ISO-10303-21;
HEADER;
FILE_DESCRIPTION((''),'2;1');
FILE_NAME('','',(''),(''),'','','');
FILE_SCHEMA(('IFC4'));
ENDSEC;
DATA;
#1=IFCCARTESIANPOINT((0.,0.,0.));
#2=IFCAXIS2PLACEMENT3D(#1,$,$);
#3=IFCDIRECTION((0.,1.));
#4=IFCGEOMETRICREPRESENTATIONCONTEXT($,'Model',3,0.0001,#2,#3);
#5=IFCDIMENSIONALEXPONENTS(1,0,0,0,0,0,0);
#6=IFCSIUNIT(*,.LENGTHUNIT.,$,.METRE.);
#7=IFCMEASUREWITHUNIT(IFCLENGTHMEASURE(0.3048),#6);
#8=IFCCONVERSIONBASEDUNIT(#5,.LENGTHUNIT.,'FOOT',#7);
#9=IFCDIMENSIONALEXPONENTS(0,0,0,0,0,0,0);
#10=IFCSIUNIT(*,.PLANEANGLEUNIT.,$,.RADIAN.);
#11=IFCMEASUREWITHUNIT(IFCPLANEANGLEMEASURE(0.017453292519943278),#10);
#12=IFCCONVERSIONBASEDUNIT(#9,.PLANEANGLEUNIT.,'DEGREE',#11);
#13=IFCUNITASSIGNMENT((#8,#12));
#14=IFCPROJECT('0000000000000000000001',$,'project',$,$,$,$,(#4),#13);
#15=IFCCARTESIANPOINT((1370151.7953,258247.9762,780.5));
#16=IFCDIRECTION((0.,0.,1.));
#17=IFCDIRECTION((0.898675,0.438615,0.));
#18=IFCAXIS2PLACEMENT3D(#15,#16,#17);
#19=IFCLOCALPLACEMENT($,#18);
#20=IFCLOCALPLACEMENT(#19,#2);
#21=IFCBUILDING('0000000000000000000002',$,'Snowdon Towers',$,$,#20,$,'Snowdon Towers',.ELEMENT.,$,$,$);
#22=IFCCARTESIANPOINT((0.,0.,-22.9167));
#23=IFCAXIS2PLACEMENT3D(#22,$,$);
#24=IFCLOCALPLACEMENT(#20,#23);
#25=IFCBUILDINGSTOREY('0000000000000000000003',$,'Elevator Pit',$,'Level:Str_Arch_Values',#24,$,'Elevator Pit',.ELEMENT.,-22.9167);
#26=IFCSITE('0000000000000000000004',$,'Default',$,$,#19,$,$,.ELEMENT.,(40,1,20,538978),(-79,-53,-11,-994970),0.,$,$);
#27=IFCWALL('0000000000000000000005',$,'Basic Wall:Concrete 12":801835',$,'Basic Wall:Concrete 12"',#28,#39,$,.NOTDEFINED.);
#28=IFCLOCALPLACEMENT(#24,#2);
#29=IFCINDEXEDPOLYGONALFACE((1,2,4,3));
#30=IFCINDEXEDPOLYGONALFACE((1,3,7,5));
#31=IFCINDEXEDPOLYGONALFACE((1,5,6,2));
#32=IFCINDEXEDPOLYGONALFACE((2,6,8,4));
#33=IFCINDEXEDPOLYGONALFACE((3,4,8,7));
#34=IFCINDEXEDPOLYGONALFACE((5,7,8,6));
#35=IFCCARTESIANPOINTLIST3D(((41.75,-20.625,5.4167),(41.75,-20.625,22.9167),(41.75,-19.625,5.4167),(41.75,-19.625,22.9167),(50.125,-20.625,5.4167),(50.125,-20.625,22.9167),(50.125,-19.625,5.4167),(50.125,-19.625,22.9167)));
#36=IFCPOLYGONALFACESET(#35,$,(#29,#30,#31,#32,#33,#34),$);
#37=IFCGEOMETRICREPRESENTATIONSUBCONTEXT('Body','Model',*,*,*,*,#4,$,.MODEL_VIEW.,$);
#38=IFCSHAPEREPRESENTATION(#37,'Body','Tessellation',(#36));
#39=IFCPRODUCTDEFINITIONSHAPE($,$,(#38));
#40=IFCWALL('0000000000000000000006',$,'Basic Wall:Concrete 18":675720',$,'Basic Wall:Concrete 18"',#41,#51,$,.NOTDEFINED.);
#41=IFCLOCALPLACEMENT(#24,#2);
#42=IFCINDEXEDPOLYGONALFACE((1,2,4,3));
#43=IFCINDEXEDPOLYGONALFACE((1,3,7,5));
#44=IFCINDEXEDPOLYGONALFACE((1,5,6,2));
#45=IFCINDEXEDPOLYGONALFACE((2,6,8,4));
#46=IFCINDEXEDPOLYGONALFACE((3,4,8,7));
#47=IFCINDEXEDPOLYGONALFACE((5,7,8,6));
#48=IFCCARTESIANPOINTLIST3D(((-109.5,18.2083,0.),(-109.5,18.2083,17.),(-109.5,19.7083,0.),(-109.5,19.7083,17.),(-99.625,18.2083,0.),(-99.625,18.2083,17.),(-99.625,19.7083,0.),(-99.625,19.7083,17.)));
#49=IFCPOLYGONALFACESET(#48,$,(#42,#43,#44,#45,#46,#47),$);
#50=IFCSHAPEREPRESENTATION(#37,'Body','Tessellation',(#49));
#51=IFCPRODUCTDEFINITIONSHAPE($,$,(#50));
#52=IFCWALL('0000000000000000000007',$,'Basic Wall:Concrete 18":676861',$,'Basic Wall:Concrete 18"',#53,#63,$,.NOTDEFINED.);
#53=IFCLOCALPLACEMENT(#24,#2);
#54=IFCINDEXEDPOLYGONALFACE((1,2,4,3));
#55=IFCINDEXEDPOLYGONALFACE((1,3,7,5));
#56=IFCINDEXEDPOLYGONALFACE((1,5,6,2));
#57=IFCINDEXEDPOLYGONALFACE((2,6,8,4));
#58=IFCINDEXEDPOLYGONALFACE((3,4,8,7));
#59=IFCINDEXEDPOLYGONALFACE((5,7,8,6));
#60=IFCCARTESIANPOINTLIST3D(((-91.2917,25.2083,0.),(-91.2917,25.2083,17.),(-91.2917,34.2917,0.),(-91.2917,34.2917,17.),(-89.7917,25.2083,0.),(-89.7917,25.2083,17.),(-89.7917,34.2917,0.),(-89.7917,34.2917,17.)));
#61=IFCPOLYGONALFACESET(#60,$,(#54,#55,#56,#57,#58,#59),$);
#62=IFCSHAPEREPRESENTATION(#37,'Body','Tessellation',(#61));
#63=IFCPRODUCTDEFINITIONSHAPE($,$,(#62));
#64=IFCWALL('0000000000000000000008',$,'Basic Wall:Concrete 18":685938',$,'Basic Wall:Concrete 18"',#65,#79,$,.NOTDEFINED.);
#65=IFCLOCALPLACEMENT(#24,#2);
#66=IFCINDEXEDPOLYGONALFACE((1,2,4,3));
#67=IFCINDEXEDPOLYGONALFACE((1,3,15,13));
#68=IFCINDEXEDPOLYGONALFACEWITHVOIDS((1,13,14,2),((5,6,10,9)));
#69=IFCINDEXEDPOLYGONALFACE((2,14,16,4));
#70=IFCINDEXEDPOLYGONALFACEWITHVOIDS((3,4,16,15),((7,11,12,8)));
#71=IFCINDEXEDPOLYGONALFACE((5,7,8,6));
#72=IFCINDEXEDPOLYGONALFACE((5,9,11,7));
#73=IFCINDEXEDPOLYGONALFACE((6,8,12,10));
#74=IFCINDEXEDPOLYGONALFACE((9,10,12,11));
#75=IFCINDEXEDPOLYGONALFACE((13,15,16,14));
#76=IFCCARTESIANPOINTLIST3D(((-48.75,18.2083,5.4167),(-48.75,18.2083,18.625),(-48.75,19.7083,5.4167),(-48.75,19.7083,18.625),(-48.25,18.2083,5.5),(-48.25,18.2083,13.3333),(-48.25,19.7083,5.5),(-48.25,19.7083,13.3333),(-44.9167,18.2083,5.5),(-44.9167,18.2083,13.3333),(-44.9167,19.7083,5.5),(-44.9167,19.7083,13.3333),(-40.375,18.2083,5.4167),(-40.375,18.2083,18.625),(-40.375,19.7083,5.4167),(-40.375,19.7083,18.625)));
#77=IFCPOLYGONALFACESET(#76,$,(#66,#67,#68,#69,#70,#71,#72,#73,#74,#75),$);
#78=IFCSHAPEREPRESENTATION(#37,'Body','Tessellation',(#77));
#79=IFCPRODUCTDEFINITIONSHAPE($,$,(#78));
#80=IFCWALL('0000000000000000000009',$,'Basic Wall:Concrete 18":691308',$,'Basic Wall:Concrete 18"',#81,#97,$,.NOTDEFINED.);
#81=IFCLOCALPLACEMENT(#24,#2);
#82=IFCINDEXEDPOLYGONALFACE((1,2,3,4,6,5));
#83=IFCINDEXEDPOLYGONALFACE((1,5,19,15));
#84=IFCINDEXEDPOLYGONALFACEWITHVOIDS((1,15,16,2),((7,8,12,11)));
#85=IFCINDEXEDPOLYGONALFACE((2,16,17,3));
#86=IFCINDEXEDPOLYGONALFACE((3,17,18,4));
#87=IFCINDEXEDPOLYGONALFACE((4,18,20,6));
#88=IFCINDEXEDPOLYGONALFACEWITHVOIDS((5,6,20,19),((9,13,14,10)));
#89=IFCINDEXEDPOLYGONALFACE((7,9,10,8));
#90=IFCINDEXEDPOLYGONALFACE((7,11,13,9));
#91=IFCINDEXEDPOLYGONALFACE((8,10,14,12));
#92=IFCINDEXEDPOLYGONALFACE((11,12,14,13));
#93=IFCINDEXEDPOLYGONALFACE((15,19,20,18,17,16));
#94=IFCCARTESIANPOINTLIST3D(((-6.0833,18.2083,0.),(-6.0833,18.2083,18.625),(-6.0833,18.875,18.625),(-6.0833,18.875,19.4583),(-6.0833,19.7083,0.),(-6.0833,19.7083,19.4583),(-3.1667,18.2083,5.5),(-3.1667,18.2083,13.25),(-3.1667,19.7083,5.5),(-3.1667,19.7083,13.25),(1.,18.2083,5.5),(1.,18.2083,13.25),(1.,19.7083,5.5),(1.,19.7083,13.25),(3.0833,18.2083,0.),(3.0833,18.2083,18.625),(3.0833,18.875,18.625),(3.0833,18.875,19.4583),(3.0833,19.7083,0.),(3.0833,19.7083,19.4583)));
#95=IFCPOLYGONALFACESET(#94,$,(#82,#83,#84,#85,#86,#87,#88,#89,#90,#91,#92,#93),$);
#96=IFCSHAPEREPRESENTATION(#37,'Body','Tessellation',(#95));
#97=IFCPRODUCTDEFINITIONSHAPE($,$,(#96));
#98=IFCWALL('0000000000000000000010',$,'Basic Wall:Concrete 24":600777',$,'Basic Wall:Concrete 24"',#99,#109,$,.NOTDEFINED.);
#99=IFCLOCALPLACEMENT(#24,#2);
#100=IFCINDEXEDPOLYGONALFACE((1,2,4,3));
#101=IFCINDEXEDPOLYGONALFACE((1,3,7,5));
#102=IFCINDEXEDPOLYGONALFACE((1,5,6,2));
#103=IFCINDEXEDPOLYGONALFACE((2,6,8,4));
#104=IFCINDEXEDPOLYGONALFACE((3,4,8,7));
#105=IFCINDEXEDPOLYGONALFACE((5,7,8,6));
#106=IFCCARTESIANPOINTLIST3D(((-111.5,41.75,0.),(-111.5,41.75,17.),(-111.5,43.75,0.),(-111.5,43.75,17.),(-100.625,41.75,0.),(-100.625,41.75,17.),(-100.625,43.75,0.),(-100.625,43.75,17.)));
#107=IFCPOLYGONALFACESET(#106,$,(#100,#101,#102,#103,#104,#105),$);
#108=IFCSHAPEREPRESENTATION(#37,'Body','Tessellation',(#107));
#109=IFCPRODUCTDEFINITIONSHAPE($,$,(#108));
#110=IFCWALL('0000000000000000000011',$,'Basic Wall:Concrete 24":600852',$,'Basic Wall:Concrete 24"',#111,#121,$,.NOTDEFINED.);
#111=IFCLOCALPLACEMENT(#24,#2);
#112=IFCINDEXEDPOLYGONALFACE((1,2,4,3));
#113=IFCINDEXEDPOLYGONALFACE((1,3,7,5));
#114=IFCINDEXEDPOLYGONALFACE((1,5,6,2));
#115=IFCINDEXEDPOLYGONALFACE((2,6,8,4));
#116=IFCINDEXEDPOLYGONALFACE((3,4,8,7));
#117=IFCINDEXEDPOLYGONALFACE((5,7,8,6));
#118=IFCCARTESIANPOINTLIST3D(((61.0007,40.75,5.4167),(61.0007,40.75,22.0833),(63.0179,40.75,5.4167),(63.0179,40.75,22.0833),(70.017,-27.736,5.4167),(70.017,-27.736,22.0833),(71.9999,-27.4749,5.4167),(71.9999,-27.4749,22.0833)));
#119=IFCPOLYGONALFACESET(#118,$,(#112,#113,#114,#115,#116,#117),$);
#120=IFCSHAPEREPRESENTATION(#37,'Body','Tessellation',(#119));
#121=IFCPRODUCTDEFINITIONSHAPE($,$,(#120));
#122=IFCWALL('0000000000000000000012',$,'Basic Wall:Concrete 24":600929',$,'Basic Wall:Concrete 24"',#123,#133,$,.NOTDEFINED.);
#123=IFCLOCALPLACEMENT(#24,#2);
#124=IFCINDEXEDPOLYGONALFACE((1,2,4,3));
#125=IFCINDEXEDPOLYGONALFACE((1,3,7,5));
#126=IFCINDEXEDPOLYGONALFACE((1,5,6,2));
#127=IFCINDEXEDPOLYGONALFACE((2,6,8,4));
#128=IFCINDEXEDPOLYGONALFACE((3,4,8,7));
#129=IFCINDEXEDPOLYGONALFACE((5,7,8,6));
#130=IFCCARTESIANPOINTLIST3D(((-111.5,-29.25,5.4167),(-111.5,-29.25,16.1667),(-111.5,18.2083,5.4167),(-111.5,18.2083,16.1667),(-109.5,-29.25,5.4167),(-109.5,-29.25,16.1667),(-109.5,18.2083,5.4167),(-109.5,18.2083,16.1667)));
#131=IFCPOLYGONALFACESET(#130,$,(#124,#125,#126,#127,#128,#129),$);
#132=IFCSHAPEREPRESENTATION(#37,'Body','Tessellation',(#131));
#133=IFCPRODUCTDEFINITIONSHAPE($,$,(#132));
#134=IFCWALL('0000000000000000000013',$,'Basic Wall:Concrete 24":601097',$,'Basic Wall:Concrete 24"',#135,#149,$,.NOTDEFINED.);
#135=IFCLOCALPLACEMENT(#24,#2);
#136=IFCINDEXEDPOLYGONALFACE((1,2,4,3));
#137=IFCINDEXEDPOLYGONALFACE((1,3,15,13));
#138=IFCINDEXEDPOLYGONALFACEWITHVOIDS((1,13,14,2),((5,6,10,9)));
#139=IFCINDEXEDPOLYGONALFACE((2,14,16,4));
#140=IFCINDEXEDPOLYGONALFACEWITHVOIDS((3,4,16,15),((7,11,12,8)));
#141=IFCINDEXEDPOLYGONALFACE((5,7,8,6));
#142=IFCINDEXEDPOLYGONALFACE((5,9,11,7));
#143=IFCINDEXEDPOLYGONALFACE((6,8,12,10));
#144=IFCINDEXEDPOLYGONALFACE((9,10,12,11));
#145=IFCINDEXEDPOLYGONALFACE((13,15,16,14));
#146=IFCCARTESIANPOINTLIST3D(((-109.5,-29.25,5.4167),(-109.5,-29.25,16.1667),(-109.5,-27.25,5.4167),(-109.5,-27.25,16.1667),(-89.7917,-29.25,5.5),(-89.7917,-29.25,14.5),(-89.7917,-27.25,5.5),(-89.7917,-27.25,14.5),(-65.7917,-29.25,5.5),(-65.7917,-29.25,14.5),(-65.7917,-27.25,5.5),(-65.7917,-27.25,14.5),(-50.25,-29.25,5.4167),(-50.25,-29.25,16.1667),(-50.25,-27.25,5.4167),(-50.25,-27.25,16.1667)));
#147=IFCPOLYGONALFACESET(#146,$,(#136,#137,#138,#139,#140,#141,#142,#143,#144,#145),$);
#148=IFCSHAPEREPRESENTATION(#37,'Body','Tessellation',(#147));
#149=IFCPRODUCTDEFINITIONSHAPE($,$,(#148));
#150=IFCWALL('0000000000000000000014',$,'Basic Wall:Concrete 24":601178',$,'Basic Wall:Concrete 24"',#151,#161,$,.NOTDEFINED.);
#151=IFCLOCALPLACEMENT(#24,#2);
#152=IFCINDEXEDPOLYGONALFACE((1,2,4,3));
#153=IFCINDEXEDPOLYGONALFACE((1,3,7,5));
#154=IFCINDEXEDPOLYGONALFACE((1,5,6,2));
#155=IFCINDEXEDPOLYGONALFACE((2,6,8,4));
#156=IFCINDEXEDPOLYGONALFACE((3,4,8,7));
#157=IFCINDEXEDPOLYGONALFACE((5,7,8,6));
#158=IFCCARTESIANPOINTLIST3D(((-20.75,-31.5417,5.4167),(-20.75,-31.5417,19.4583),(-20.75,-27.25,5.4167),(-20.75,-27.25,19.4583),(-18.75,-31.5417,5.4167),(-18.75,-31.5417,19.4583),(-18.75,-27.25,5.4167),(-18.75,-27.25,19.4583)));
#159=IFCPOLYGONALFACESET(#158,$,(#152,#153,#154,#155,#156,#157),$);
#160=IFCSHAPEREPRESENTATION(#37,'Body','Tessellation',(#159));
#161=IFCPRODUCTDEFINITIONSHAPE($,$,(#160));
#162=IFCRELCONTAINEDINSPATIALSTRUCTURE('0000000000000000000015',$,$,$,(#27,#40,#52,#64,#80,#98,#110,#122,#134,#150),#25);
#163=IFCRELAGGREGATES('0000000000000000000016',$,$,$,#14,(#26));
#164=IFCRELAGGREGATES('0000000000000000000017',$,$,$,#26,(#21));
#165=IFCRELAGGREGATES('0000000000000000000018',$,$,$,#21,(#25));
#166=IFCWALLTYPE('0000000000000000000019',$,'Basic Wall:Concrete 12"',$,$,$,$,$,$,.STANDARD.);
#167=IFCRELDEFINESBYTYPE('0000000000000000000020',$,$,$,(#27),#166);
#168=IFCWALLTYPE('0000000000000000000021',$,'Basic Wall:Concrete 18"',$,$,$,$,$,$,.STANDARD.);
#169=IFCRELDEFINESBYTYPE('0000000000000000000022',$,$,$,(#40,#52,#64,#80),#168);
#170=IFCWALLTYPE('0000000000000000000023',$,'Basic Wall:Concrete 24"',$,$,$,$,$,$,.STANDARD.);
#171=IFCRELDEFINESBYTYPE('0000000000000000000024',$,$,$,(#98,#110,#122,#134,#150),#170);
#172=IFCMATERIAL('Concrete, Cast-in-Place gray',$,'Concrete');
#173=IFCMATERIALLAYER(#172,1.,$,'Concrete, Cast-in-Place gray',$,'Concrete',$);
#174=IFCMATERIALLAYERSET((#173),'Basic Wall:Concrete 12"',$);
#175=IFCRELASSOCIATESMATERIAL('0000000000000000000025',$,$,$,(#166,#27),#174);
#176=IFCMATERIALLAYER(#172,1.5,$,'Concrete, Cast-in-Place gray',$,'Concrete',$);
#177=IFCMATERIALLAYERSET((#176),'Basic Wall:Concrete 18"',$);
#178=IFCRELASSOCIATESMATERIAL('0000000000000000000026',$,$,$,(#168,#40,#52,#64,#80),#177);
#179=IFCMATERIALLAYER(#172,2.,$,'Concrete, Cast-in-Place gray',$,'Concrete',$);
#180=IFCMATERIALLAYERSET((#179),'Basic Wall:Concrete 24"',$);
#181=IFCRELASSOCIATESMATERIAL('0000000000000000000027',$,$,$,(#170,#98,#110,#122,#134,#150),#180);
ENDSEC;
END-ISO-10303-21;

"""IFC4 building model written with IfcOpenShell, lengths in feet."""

from ifc_helpers import new_model, entity, si_unit, converted_unit, direction, frame, frame_2d, origin, origin_2d_with_axis, place, context, subcontext, project, spatial, polyline, rectangle, outline, extrude, clip, bounded_halfspace, material, layer, layer_set, layer_usage, type_object, element, save


model = new_model("IFC4")

# Units and contexts
model_context = context("Model", 3, precision=0.0001, world=origin(), true_north=direction((0.0, 1.0)))
body_context = subcontext(model_context, "Body", "Model", "MODEL_VIEW")
ifc_project = project(units=[converted_unit("LENGTHUNIT", "FOOT", entity("IfcLengthMeasure", 0.3048), si_unit("LENGTHUNIT", "METRE"), dimensions=[1, 0, 0, 0, 0, 0, 0]), converted_unit("PLANEANGLEUNIT", "DEGREE", entity("IfcPlaneAngleMeasure", 0.017453292519943278), si_unit("PLANEANGLEUNIT", "RADIAN"), dimensions=[0, 0, 0, 0, 0, 0, 0])], contexts=[model_context])

# Site, building, storey
site_placement = place(None, frame((1370151.7953, 258247.9762, 780.5), z_axis=(0.0, 0.0, 1.0), x_axis=(0.898675, 0.438615, 0.0)))
site = spatial("IfcSite", under=ifc_project, at=site_placement, Name="Default", CompositionType="ELEMENT", RefLatitude=(40, 1, 20, 538978), RefLongitude=(-79, -53, -11, -994970), RefElevation=0.0)
building_placement = place(site_placement, origin())
building = spatial("IfcBuilding", under=site, at=building_placement, Name="Snowdon Towers", LongName="Snowdon Towers", CompositionType="ELEMENT")
storey_placement = place(building_placement, frame((0.0, 0.0, -22.9167)))
storey = spatial("IfcBuildingStorey", under=building, at=storey_placement, Name="Elevator Pit", ObjectType="Level:Str_Arch_Values", LongName="Elevator Pit", CompositionType="ELEMENT", Elevation=-22.9167)

# Shared definitions
ifc_material = material(Name="Concrete, Cast-in-Place gray", Category="Concrete")

# Shared definitions
ifc_layer_1 = layer(ifc_material, 1.0, Name="Concrete, Cast-in-Place gray", Category="Concrete")
ifc_layer_set_1 = layer_set([ifc_layer_1], Name="Basic Wall:Concrete 12\"")
wall_type_1 = type_object("IfcWallType", Name="Basic Wall:Concrete 12\"", PredefinedType="STANDARD", material=ifc_layer_set_1)

# Walls
ifc_layer_usage_1 = layer_usage(ifc_layer_set_1, "AXIS2", "POSITIVE", -0.5)
wall_1_placement = place(storey_placement, frame((50.125, -20.125, 5.4167), z_axis=(0.0, 0.0, 1.0), x_axis=(-1.0, 0.0, 0.0)))
element("IfcWall", 1, at=wall_1_placement, inside=storey, type_object=wall_type_1, material=ifc_layer_usage_1, Name="Basic Wall:Concrete 12\":801835", ObjectType="Basic Wall:Concrete 12\"", PredefinedType="NOTDEFINED", context=body_context, shape_type="SweptSolid", body=[
    extrude(rectangle(XDim=8.375, YDim=1.0, at=frame_2d((4.1875, 0.0), x_axis=(-1.0, 0.0))), origin(), (0.0, 0.0, 1.0), 17.5),
])
ifc_layer_2 = layer(ifc_material, 1.5, Name="Concrete, Cast-in-Place gray", Category="Concrete")
ifc_layer_set_2 = layer_set([ifc_layer_2], Name="Basic Wall:Concrete 18\"")
ifc_layer_usage_2 = layer_usage(ifc_layer_set_2, "AXIS2", "POSITIVE", -0.75)
wall_type_2 = type_object("IfcWallType", Name="Basic Wall:Concrete 18\"", PredefinedType="STANDARD", material=ifc_layer_set_2)
wall_2_placement = place(storey_placement, frame((-99.625, 18.9583, 0.0), z_axis=(0.0, 0.0, 1.0), x_axis=(-1.0, 0.0, 0.0)))
element("IfcWall", 2, at=wall_2_placement, inside=storey, type_object=wall_type_2, material=ifc_layer_usage_2, Name="Basic Wall:Concrete 18\":675720", ObjectType="Basic Wall:Concrete 18\"", PredefinedType="NOTDEFINED", context=body_context, shape_type="SweptSolid", body=[
    extrude(rectangle(XDim=9.875, YDim=1.5, at=frame_2d((4.9375, 0.0), x_axis=(-1.0, 0.0))), origin(), (0.0, 0.0, 1.0), 17.0),
])
ifc_layer_usage_3 = layer_usage(ifc_layer_set_2, "AXIS2", "POSITIVE", -0.75)
wall_3_placement = place(storey_placement, frame((-90.5417, 34.2917, 0.0), z_axis=(0.0, 0.0, 1.0), x_axis=(0.0, -1.0, 0.0)))
element("IfcWall", 3, at=wall_3_placement, inside=storey, type_object=wall_type_2, material=ifc_layer_usage_3, Name="Basic Wall:Concrete 18\":676861", ObjectType="Basic Wall:Concrete 18\"", PredefinedType="NOTDEFINED", context=body_context, shape_type="SweptSolid", body=[
    extrude(rectangle(XDim=9.0833, YDim=1.5, at=frame_2d((4.5417, 0.0), x_axis=(-1.0, 0.0))), origin(), (0.0, 0.0, 1.0), 17.0),
])

# Walls, openings
ifc_layer_usage_4 = layer_usage(ifc_layer_set_2, "AXIS2", "POSITIVE", -0.75)
wall_4_placement = place(storey_placement, frame((-40.375, 18.9583, 5.4167), z_axis=(0.0, 0.0, 1.0), x_axis=(-1.0, 0.0, 0.0)))
wall_4 = element("IfcWall", 4, at=wall_4_placement, inside=storey, type_object=wall_type_2, material=ifc_layer_usage_4, Name="Basic Wall:Concrete 18\":685938", ObjectType="Basic Wall:Concrete 18\"", PredefinedType="NOTDEFINED", context=body_context, shape_type="Clipping", body=[
    clip(extrude(rectangle(XDim=8.375, YDim=1.5, at=frame_2d((4.1875, 0.0), x_axis=(-1.0, 0.0))), origin(), (0.0, 0.0, 1.0), 13.2083), bounded_halfspace(frame((0.0, -0.75, 13.2083), z_axis=(0.0, 0.0, -1.0), x_axis=(1.0, 0.0, 0.0)), True, frame((0.0, -0.75, 13.2083), z_axis=(0.0, 0.0, -1.0), x_axis=(1.0, 0.0, 0.0)), polyline([(0.0, 0.0), (0.0, -1.5), (7.875, -1.5), (8.375, -1.5), (8.375, 0.0), (0.0, 0.0)]))),
])
opening_1_placement = place(wall_4_placement, origin())
element("IfcOpeningElement", 5, at=opening_1_placement, cuts=wall_4, PredefinedType="OPENING", context=body_context, shape_type="SweptSolid", body=[
    extrude(rectangle(XDim=7.8333, YDim=3.3333, at=frame_2d((0.0, 0.0), x_axis=(0.0, 1.0))), frame((6.2083, -5.75, 4.0), z_axis=(0.0, 1.0, 0.0), x_axis=(-1.0, 0.0, 0.0)), (0.0, 0.0, 1.0), 10.0),
])
ifc_layer_usage_5 = layer_usage(ifc_layer_set_2, "AXIS2", "NEGATIVE", 0.75)
wall_5_placement = place(storey_placement, frame((-6.0833, 18.9583, 0.0)))
wall_5 = element("IfcWall", 6, at=wall_5_placement, inside=storey, type_object=wall_type_2, material=ifc_layer_usage_5, Name="Basic Wall:Concrete 18\":691308", ObjectType="Basic Wall:Concrete 18\"", PredefinedType="NOTDEFINED", context=body_context, shape_type="Clipping", body=[
    clip(clip(extrude(rectangle(XDim=9.1667, YDim=1.5, at=frame_2d((4.5833, 0.0), x_axis=(-1.0, 0.0))), origin(), (0.0, 0.0, 1.0), 19.4583), bounded_halfspace(frame((9.1667, -0.0833, 18.625), z_axis=(0.0, 0.0, -1.0), x_axis=(-1.0, 0.0, 0.0)), True, frame((9.1667, -0.0833, 18.625), z_axis=(0.0, 0.0, -1.0), x_axis=(-1.0, 0.0, 0.0)), polyline([(0.0, 0.0), (0.0, -0.6667), (0.5, -0.6667), (9.1667, -0.6667), (9.1667, 0.0), (0.0, 0.0)]))), bounded_halfspace(frame((0.0, -0.0833, 18.625), z_axis=(0.0, 1.0, 0.0), x_axis=(0.0, 0.0, 1.0)), True, frame((0.0, -0.0833, 18.625), z_axis=(0.0, 1.0, 0.0), x_axis=(0.0, 0.0, 1.0)), polyline([(0.0, 0.0), (0.8333, 0.0), (0.8333, 9.1667), (0.0, 9.1667), (0.0, 0.0)]))),
])
opening_2_placement = place(wall_5_placement, origin())
element("IfcOpeningElement", 7, at=opening_2_placement, cuts=wall_5, PredefinedType="OPENING", context=body_context, shape_type="SweptSolid", body=[
    extrude(rectangle(XDim=7.75, YDim=4.1667, at=origin_2d_with_axis()), frame((5.0, -4.25, 9.375), z_axis=(0.0, 1.0, 0.0), x_axis=(0.0, 0.0, 1.0)), (0.0, 0.0, 1.0), 10.0),
])

# Walls
ifc_layer_3 = layer(ifc_material, 2.0, Name="Concrete, Cast-in-Place gray", Category="Concrete")
ifc_layer_set_3 = layer_set([ifc_layer_3], Name="Basic Wall:Concrete 24\"")
ifc_layer_usage_6 = layer_usage(ifc_layer_set_3, "AXIS2", "NEGATIVE", 1.0)
wall_type_3 = type_object("IfcWallType", Name="Basic Wall:Concrete 24\"", PredefinedType="STANDARD", material=ifc_layer_set_3)
wall_6_placement = place(storey_placement, frame((-111.5, 42.75, 0.0)))
element("IfcWall", 8, at=wall_6_placement, inside=storey, type_object=wall_type_3, material=ifc_layer_usage_6, Name="Basic Wall:Concrete 24\":600777", ObjectType="Basic Wall:Concrete 24\"", PredefinedType="NOTDEFINED", context=body_context, shape_type="SweptSolid", body=[
    extrude(rectangle(XDim=10.875, YDim=2.0, at=frame_2d((5.4375, 0.0), x_axis=(-1.0, 0.0))), origin(), (0.0, 0.0, 1.0), 17.0),
])
ifc_layer_usage_7 = layer_usage(ifc_layer_set_3, "AXIS2", "NEGATIVE", 1.0)
wall_7_placement = place(storey_placement, frame((61.9921, 40.8805, 5.4167), z_axis=(0.0, 0.0, 1.0), x_axis=(0.130526, -0.991445, 0.0)))
element("IfcWall", 9, at=wall_7_placement, inside=storey, type_object=wall_type_3, material=ifc_layer_usage_7, Name="Basic Wall:Concrete 24\":600852", ObjectType="Basic Wall:Concrete 24\"", PredefinedType="NOTDEFINED", context=body_context, shape_type="Clipping", body=[
    clip(extrude(outline(polyline([(69.0769, -1.0), (69.0769, 1.0), (0.2633, 1.0), (0.0, -1.0), (67.0769, -1.0), (69.0769, -1.0)])), origin(), (0.0, 0.0, 1.0), 16.6667), bounded_halfspace(frame((0.0, -1.0, 16.6667), z_axis=(0.0, 0.0, -1.0), x_axis=(-0.130526, -0.991445, 0.0)), True, frame((0.0, -1.0, 16.6667), z_axis=(0.0, 0.0, -1.0), x_axis=(-0.130526, -0.991445, 0.0)), polyline([(0.0, 0.0), (-2.0173, 0.0), (-10.9992, -68.2249), (-9.0163, -68.486), (-8.7553, -66.5031), (0.0, 0.0)]))),
])
ifc_layer_usage_8 = layer_usage(ifc_layer_set_3, "AXIS2", "NEGATIVE", 1.0)
wall_8_placement = place(storey_placement, frame((-110.5, -29.25, 5.4167), z_axis=(0.0, 0.0, 1.0), x_axis=(0.0, 1.0, 0.0)))
element("IfcWall", 10, at=wall_8_placement, inside=storey, type_object=wall_type_3, material=ifc_layer_usage_8, Name="Basic Wall:Concrete 24\":600929", ObjectType="Basic Wall:Concrete 24\"", PredefinedType="NOTDEFINED", context=body_context, shape_type="Clipping", body=[
    clip(extrude(rectangle(XDim=47.4583, YDim=2.0, at=frame_2d((23.7292, 0.0), x_axis=(-1.0, 0.0))), origin(), (0.0, 0.0, 1.0), 10.75), bounded_halfspace(frame((0.0, -1.0, 10.75), z_axis=(0.0, 0.0, -1.0), x_axis=(0.0, -1.0, 0.0)), True, frame((0.0, -1.0, 10.75), z_axis=(0.0, 0.0, -1.0), x_axis=(0.0, -1.0, 0.0)), polyline([(0.0, 0.0), (-2.0, 0.0), (-2.0, -47.4583), (0.0, -47.4583), (0.0, -24.4583), (0.0, -22.4583), (0.0, -2.0), (0.0, 0.0)]))),
])

# Wall, opening
ifc_layer_usage_9 = layer_usage(ifc_layer_set_3, "AXIS2", "POSITIVE", -1.0)
wall_9_placement = place(storey_placement, frame((-109.5, -28.25, 5.4167)))
wall_9 = element("IfcWall", 11, at=wall_9_placement, inside=storey, type_object=wall_type_3, material=ifc_layer_usage_9, Name="Basic Wall:Concrete 24\":601097", ObjectType="Basic Wall:Concrete 24\"", PredefinedType="NOTDEFINED", context=body_context, shape_type="Clipping", body=[
    clip(extrude(rectangle(XDim=59.25, YDim=2.0, at=frame_2d((29.625, 0.0), x_axis=(-1.0, 0.0))), origin(), (0.0, 0.0, 1.0), 10.75), bounded_halfspace(frame((0.0, -1.0, 10.75), z_axis=(0.0, 0.0, -1.0), x_axis=(1.0, 0.0, 0.0)), True, frame((0.0, -1.0, 10.75), z_axis=(0.0, 0.0, -1.0), x_axis=(1.0, 0.0, 0.0)), polyline([(0.0, 0.0), (0.0, -2.0), (17.7083, -2.0), (19.7083, -2.0), (38.5, -2.0), (40.5, -2.0), (59.25, -2.0), (59.25, 0.0), (0.0, 0.0)]))),
])
opening_3_placement = place(wall_9_placement, origin())
element("IfcOpeningElement", 12, at=opening_3_placement, cuts=wall_9, PredefinedType="OPENING", context=body_context, shape_type="SweptSolid", body=[
    extrude(rectangle(XDim=9.0, YDim=24.0, at=frame_2d((0.0, 0.0), x_axis=(1.0, 0.0))), frame((31.7083, -4.0, 4.5833), z_axis=(0.0, 1.0, 0.0), x_axis=(0.0, 0.0, 1.0)), (0.0, 0.0, 1.0), 10.0),
])

# Wall
ifc_layer_usage_10 = layer_usage(ifc_layer_set_3, "AXIS2", "POSITIVE", -1.0)
wall_10_placement = place(storey_placement, frame((-19.75, -27.25, 5.4167), z_axis=(0.0, 0.0, 1.0), x_axis=(0.0, -1.0, 0.0)))
element("IfcWall", 13, at=wall_10_placement, inside=storey, type_object=wall_type_3, material=ifc_layer_usage_10, Name="Basic Wall:Concrete 24\":601178", ObjectType="Basic Wall:Concrete 24\"", PredefinedType="NOTDEFINED", context=body_context, shape_type="SweptSolid", body=[
    extrude(rectangle(XDim=4.2917, YDim=2.0, at=frame_2d((2.1458, 0.0), x_axis=(-1.0, 0.0))), origin(), (0.0, 0.0, 1.0), 14.0417),
])

save(model, "model.ifc")
